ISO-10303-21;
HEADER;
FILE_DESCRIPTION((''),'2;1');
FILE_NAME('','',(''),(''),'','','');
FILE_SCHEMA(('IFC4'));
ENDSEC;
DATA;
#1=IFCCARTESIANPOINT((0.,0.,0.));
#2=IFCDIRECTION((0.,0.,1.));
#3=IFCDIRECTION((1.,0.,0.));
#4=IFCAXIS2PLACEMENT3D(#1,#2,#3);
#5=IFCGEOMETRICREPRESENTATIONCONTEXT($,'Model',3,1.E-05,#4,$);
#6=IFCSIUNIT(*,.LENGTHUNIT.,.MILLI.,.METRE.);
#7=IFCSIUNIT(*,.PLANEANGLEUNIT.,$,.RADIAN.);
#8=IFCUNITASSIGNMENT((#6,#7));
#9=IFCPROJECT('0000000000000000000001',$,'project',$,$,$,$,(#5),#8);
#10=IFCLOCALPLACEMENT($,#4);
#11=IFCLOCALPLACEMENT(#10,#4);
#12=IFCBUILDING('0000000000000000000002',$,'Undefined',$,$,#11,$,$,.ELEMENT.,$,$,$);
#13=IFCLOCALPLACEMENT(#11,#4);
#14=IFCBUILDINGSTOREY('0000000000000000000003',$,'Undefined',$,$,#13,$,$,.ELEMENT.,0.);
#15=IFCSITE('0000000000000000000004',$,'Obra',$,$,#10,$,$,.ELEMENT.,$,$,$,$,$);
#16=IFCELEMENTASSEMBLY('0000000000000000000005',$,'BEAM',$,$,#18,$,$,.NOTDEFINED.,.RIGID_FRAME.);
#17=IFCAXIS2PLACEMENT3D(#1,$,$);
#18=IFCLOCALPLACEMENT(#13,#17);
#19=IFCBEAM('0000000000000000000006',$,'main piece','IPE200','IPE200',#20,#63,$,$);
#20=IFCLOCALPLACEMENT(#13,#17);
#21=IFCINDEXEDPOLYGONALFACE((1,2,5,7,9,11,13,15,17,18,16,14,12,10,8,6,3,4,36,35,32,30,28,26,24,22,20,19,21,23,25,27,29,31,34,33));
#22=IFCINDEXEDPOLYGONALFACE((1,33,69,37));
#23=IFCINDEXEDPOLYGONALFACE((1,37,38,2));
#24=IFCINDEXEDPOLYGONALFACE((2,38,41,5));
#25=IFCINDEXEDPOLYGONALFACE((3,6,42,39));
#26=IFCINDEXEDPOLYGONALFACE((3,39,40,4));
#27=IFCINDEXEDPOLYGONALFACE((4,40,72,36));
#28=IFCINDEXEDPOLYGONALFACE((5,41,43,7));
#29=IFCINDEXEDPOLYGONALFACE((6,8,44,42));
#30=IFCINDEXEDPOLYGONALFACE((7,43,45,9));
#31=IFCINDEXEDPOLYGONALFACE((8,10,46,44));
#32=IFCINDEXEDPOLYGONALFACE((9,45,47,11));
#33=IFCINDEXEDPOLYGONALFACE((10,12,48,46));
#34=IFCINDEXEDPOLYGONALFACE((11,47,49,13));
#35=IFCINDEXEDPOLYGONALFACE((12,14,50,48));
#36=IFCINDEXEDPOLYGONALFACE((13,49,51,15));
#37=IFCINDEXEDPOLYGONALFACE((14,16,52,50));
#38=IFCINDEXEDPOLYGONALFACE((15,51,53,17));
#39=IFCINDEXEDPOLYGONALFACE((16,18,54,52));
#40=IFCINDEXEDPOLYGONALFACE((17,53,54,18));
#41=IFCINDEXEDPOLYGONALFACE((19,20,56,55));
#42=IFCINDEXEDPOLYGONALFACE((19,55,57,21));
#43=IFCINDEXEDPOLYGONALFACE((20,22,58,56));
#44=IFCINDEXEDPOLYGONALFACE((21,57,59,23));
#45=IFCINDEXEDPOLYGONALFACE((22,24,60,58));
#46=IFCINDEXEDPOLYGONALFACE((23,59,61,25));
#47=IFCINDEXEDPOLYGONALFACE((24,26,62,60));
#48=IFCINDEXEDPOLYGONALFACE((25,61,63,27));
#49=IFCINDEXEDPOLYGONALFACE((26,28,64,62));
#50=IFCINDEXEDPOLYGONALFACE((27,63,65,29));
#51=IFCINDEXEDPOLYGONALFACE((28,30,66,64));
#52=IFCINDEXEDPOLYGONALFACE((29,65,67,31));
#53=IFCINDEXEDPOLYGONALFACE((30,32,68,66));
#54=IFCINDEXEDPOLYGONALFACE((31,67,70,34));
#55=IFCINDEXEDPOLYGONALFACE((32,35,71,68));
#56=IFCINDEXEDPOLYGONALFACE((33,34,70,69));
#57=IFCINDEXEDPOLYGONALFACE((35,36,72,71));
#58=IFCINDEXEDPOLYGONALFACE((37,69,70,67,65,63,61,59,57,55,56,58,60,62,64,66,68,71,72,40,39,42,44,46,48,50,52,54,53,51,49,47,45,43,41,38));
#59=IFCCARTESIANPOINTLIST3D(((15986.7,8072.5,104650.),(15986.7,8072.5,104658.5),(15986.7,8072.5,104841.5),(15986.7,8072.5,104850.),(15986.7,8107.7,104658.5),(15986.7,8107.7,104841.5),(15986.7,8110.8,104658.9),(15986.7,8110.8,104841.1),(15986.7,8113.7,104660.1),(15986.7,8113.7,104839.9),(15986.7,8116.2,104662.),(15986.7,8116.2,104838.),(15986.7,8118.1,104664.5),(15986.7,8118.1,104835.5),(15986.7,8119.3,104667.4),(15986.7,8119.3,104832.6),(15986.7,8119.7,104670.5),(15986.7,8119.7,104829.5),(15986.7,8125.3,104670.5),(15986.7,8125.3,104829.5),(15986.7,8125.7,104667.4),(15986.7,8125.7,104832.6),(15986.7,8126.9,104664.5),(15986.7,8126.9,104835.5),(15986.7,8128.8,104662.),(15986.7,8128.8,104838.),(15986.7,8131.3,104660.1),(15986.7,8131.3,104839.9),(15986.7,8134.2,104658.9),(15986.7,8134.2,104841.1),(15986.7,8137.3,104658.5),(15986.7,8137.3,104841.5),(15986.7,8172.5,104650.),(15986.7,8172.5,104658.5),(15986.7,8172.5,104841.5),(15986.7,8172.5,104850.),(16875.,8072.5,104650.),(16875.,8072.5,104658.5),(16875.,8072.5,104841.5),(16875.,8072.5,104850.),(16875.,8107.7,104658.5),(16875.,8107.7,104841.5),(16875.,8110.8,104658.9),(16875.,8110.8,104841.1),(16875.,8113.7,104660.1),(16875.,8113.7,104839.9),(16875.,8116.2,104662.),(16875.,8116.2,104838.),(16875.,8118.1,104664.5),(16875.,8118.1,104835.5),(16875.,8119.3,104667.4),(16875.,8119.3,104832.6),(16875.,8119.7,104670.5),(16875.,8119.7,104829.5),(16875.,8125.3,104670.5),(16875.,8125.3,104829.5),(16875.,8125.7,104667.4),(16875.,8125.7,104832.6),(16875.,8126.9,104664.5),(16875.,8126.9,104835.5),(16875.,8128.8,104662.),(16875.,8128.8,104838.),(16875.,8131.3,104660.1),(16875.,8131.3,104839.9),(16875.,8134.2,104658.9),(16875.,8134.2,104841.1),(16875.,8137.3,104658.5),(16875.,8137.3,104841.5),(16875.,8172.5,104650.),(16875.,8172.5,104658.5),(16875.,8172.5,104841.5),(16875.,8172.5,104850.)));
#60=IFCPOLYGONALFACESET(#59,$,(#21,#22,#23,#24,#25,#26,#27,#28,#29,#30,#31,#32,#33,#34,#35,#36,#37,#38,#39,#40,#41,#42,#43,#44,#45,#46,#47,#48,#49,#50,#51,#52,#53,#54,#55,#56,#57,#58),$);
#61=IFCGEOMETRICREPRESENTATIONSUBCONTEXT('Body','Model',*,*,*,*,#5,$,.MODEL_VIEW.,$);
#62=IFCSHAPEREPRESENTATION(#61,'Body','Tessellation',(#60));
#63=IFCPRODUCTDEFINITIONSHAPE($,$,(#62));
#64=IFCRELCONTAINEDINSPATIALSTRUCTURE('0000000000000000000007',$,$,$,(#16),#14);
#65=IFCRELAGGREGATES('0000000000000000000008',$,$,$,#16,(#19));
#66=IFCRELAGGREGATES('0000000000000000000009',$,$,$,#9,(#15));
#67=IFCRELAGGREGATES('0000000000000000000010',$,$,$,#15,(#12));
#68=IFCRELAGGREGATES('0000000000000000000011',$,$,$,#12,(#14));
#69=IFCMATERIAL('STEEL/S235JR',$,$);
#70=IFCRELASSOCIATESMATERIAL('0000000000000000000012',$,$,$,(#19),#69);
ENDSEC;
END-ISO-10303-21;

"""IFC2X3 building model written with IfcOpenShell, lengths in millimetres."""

from ifc_helpers import new_model, si_unit, frame, origin_with_axes, origin_2d_with_axis, place, context, subcontext, project, spatial, i_section, extrude, material, element, aggregate, save


model = new_model("IFC2X3")

# Units and contexts
model_context = context("Model", 3, precision=1e-05, world=origin_with_axes())
body_context = subcontext(model_context, "Body", "Model", "MODEL_VIEW")
ifc_project = project(units=[si_unit("LENGTHUNIT", "METRE", prefix="MILLI"), si_unit("PLANEANGLEUNIT", "RADIAN")], contexts=[model_context])

# Site, building, storey
site_placement = place(None, origin_with_axes())
site = spatial("IfcSite", under=ifc_project, at=site_placement, Name="Obra", CompositionType="ELEMENT")
building_placement = place(site_placement, origin_with_axes())
building = spatial("IfcBuilding", under=site, at=building_placement, Name="Undefined", CompositionType="ELEMENT")
storey_placement = place(building_placement, origin_with_axes())
storey = spatial("IfcBuildingStorey", under=building, at=storey_placement, Name="Undefined", CompositionType="ELEMENT", Elevation=0.0)

# Shared definitions
ifc_material_1 = material(Name="STEEL/S235JR")

# Element assembly, beam
assembly_1_placement = place(storey_placement, origin_with_axes())
assembly_1 = element("IfcElementAssembly", 1, at=assembly_1_placement, inside=storey, Name="BEAM", AssemblyPlace="NOTDEFINED", PredefinedType="RIGID_FRAME")
beam_1_placement = place(assembly_1_placement, frame((15986.7, 8122.5, 104750.0), z_axis=(0.0, 0.0, 1.0), x_axis=(1.0, 0.0, 0.0)))
beam_1 = element("IfcBeam", 2, at=beam_1_placement, material=ifc_material_1, Name="main piece", Description="IPE200", ObjectType="IPE200", context=body_context, shape_type="SweptSolid", body=[
    extrude(i_section(OverallWidth=100.0, OverallDepth=200.0, WebThickness=5.6, FlangeThickness=8.5, FilletRadius=12.0, at=origin_2d_with_axis()), frame((888.3, 0.0, 0.0), z_axis=(-1.0, 0.0, 0.0), x_axis=(0.0, -1.0, 0.0)), (0.0, 0.0, 1.0), 888.3),
])
aggregate(assembly_1, [beam_1])

save(model, "model.ifc")
